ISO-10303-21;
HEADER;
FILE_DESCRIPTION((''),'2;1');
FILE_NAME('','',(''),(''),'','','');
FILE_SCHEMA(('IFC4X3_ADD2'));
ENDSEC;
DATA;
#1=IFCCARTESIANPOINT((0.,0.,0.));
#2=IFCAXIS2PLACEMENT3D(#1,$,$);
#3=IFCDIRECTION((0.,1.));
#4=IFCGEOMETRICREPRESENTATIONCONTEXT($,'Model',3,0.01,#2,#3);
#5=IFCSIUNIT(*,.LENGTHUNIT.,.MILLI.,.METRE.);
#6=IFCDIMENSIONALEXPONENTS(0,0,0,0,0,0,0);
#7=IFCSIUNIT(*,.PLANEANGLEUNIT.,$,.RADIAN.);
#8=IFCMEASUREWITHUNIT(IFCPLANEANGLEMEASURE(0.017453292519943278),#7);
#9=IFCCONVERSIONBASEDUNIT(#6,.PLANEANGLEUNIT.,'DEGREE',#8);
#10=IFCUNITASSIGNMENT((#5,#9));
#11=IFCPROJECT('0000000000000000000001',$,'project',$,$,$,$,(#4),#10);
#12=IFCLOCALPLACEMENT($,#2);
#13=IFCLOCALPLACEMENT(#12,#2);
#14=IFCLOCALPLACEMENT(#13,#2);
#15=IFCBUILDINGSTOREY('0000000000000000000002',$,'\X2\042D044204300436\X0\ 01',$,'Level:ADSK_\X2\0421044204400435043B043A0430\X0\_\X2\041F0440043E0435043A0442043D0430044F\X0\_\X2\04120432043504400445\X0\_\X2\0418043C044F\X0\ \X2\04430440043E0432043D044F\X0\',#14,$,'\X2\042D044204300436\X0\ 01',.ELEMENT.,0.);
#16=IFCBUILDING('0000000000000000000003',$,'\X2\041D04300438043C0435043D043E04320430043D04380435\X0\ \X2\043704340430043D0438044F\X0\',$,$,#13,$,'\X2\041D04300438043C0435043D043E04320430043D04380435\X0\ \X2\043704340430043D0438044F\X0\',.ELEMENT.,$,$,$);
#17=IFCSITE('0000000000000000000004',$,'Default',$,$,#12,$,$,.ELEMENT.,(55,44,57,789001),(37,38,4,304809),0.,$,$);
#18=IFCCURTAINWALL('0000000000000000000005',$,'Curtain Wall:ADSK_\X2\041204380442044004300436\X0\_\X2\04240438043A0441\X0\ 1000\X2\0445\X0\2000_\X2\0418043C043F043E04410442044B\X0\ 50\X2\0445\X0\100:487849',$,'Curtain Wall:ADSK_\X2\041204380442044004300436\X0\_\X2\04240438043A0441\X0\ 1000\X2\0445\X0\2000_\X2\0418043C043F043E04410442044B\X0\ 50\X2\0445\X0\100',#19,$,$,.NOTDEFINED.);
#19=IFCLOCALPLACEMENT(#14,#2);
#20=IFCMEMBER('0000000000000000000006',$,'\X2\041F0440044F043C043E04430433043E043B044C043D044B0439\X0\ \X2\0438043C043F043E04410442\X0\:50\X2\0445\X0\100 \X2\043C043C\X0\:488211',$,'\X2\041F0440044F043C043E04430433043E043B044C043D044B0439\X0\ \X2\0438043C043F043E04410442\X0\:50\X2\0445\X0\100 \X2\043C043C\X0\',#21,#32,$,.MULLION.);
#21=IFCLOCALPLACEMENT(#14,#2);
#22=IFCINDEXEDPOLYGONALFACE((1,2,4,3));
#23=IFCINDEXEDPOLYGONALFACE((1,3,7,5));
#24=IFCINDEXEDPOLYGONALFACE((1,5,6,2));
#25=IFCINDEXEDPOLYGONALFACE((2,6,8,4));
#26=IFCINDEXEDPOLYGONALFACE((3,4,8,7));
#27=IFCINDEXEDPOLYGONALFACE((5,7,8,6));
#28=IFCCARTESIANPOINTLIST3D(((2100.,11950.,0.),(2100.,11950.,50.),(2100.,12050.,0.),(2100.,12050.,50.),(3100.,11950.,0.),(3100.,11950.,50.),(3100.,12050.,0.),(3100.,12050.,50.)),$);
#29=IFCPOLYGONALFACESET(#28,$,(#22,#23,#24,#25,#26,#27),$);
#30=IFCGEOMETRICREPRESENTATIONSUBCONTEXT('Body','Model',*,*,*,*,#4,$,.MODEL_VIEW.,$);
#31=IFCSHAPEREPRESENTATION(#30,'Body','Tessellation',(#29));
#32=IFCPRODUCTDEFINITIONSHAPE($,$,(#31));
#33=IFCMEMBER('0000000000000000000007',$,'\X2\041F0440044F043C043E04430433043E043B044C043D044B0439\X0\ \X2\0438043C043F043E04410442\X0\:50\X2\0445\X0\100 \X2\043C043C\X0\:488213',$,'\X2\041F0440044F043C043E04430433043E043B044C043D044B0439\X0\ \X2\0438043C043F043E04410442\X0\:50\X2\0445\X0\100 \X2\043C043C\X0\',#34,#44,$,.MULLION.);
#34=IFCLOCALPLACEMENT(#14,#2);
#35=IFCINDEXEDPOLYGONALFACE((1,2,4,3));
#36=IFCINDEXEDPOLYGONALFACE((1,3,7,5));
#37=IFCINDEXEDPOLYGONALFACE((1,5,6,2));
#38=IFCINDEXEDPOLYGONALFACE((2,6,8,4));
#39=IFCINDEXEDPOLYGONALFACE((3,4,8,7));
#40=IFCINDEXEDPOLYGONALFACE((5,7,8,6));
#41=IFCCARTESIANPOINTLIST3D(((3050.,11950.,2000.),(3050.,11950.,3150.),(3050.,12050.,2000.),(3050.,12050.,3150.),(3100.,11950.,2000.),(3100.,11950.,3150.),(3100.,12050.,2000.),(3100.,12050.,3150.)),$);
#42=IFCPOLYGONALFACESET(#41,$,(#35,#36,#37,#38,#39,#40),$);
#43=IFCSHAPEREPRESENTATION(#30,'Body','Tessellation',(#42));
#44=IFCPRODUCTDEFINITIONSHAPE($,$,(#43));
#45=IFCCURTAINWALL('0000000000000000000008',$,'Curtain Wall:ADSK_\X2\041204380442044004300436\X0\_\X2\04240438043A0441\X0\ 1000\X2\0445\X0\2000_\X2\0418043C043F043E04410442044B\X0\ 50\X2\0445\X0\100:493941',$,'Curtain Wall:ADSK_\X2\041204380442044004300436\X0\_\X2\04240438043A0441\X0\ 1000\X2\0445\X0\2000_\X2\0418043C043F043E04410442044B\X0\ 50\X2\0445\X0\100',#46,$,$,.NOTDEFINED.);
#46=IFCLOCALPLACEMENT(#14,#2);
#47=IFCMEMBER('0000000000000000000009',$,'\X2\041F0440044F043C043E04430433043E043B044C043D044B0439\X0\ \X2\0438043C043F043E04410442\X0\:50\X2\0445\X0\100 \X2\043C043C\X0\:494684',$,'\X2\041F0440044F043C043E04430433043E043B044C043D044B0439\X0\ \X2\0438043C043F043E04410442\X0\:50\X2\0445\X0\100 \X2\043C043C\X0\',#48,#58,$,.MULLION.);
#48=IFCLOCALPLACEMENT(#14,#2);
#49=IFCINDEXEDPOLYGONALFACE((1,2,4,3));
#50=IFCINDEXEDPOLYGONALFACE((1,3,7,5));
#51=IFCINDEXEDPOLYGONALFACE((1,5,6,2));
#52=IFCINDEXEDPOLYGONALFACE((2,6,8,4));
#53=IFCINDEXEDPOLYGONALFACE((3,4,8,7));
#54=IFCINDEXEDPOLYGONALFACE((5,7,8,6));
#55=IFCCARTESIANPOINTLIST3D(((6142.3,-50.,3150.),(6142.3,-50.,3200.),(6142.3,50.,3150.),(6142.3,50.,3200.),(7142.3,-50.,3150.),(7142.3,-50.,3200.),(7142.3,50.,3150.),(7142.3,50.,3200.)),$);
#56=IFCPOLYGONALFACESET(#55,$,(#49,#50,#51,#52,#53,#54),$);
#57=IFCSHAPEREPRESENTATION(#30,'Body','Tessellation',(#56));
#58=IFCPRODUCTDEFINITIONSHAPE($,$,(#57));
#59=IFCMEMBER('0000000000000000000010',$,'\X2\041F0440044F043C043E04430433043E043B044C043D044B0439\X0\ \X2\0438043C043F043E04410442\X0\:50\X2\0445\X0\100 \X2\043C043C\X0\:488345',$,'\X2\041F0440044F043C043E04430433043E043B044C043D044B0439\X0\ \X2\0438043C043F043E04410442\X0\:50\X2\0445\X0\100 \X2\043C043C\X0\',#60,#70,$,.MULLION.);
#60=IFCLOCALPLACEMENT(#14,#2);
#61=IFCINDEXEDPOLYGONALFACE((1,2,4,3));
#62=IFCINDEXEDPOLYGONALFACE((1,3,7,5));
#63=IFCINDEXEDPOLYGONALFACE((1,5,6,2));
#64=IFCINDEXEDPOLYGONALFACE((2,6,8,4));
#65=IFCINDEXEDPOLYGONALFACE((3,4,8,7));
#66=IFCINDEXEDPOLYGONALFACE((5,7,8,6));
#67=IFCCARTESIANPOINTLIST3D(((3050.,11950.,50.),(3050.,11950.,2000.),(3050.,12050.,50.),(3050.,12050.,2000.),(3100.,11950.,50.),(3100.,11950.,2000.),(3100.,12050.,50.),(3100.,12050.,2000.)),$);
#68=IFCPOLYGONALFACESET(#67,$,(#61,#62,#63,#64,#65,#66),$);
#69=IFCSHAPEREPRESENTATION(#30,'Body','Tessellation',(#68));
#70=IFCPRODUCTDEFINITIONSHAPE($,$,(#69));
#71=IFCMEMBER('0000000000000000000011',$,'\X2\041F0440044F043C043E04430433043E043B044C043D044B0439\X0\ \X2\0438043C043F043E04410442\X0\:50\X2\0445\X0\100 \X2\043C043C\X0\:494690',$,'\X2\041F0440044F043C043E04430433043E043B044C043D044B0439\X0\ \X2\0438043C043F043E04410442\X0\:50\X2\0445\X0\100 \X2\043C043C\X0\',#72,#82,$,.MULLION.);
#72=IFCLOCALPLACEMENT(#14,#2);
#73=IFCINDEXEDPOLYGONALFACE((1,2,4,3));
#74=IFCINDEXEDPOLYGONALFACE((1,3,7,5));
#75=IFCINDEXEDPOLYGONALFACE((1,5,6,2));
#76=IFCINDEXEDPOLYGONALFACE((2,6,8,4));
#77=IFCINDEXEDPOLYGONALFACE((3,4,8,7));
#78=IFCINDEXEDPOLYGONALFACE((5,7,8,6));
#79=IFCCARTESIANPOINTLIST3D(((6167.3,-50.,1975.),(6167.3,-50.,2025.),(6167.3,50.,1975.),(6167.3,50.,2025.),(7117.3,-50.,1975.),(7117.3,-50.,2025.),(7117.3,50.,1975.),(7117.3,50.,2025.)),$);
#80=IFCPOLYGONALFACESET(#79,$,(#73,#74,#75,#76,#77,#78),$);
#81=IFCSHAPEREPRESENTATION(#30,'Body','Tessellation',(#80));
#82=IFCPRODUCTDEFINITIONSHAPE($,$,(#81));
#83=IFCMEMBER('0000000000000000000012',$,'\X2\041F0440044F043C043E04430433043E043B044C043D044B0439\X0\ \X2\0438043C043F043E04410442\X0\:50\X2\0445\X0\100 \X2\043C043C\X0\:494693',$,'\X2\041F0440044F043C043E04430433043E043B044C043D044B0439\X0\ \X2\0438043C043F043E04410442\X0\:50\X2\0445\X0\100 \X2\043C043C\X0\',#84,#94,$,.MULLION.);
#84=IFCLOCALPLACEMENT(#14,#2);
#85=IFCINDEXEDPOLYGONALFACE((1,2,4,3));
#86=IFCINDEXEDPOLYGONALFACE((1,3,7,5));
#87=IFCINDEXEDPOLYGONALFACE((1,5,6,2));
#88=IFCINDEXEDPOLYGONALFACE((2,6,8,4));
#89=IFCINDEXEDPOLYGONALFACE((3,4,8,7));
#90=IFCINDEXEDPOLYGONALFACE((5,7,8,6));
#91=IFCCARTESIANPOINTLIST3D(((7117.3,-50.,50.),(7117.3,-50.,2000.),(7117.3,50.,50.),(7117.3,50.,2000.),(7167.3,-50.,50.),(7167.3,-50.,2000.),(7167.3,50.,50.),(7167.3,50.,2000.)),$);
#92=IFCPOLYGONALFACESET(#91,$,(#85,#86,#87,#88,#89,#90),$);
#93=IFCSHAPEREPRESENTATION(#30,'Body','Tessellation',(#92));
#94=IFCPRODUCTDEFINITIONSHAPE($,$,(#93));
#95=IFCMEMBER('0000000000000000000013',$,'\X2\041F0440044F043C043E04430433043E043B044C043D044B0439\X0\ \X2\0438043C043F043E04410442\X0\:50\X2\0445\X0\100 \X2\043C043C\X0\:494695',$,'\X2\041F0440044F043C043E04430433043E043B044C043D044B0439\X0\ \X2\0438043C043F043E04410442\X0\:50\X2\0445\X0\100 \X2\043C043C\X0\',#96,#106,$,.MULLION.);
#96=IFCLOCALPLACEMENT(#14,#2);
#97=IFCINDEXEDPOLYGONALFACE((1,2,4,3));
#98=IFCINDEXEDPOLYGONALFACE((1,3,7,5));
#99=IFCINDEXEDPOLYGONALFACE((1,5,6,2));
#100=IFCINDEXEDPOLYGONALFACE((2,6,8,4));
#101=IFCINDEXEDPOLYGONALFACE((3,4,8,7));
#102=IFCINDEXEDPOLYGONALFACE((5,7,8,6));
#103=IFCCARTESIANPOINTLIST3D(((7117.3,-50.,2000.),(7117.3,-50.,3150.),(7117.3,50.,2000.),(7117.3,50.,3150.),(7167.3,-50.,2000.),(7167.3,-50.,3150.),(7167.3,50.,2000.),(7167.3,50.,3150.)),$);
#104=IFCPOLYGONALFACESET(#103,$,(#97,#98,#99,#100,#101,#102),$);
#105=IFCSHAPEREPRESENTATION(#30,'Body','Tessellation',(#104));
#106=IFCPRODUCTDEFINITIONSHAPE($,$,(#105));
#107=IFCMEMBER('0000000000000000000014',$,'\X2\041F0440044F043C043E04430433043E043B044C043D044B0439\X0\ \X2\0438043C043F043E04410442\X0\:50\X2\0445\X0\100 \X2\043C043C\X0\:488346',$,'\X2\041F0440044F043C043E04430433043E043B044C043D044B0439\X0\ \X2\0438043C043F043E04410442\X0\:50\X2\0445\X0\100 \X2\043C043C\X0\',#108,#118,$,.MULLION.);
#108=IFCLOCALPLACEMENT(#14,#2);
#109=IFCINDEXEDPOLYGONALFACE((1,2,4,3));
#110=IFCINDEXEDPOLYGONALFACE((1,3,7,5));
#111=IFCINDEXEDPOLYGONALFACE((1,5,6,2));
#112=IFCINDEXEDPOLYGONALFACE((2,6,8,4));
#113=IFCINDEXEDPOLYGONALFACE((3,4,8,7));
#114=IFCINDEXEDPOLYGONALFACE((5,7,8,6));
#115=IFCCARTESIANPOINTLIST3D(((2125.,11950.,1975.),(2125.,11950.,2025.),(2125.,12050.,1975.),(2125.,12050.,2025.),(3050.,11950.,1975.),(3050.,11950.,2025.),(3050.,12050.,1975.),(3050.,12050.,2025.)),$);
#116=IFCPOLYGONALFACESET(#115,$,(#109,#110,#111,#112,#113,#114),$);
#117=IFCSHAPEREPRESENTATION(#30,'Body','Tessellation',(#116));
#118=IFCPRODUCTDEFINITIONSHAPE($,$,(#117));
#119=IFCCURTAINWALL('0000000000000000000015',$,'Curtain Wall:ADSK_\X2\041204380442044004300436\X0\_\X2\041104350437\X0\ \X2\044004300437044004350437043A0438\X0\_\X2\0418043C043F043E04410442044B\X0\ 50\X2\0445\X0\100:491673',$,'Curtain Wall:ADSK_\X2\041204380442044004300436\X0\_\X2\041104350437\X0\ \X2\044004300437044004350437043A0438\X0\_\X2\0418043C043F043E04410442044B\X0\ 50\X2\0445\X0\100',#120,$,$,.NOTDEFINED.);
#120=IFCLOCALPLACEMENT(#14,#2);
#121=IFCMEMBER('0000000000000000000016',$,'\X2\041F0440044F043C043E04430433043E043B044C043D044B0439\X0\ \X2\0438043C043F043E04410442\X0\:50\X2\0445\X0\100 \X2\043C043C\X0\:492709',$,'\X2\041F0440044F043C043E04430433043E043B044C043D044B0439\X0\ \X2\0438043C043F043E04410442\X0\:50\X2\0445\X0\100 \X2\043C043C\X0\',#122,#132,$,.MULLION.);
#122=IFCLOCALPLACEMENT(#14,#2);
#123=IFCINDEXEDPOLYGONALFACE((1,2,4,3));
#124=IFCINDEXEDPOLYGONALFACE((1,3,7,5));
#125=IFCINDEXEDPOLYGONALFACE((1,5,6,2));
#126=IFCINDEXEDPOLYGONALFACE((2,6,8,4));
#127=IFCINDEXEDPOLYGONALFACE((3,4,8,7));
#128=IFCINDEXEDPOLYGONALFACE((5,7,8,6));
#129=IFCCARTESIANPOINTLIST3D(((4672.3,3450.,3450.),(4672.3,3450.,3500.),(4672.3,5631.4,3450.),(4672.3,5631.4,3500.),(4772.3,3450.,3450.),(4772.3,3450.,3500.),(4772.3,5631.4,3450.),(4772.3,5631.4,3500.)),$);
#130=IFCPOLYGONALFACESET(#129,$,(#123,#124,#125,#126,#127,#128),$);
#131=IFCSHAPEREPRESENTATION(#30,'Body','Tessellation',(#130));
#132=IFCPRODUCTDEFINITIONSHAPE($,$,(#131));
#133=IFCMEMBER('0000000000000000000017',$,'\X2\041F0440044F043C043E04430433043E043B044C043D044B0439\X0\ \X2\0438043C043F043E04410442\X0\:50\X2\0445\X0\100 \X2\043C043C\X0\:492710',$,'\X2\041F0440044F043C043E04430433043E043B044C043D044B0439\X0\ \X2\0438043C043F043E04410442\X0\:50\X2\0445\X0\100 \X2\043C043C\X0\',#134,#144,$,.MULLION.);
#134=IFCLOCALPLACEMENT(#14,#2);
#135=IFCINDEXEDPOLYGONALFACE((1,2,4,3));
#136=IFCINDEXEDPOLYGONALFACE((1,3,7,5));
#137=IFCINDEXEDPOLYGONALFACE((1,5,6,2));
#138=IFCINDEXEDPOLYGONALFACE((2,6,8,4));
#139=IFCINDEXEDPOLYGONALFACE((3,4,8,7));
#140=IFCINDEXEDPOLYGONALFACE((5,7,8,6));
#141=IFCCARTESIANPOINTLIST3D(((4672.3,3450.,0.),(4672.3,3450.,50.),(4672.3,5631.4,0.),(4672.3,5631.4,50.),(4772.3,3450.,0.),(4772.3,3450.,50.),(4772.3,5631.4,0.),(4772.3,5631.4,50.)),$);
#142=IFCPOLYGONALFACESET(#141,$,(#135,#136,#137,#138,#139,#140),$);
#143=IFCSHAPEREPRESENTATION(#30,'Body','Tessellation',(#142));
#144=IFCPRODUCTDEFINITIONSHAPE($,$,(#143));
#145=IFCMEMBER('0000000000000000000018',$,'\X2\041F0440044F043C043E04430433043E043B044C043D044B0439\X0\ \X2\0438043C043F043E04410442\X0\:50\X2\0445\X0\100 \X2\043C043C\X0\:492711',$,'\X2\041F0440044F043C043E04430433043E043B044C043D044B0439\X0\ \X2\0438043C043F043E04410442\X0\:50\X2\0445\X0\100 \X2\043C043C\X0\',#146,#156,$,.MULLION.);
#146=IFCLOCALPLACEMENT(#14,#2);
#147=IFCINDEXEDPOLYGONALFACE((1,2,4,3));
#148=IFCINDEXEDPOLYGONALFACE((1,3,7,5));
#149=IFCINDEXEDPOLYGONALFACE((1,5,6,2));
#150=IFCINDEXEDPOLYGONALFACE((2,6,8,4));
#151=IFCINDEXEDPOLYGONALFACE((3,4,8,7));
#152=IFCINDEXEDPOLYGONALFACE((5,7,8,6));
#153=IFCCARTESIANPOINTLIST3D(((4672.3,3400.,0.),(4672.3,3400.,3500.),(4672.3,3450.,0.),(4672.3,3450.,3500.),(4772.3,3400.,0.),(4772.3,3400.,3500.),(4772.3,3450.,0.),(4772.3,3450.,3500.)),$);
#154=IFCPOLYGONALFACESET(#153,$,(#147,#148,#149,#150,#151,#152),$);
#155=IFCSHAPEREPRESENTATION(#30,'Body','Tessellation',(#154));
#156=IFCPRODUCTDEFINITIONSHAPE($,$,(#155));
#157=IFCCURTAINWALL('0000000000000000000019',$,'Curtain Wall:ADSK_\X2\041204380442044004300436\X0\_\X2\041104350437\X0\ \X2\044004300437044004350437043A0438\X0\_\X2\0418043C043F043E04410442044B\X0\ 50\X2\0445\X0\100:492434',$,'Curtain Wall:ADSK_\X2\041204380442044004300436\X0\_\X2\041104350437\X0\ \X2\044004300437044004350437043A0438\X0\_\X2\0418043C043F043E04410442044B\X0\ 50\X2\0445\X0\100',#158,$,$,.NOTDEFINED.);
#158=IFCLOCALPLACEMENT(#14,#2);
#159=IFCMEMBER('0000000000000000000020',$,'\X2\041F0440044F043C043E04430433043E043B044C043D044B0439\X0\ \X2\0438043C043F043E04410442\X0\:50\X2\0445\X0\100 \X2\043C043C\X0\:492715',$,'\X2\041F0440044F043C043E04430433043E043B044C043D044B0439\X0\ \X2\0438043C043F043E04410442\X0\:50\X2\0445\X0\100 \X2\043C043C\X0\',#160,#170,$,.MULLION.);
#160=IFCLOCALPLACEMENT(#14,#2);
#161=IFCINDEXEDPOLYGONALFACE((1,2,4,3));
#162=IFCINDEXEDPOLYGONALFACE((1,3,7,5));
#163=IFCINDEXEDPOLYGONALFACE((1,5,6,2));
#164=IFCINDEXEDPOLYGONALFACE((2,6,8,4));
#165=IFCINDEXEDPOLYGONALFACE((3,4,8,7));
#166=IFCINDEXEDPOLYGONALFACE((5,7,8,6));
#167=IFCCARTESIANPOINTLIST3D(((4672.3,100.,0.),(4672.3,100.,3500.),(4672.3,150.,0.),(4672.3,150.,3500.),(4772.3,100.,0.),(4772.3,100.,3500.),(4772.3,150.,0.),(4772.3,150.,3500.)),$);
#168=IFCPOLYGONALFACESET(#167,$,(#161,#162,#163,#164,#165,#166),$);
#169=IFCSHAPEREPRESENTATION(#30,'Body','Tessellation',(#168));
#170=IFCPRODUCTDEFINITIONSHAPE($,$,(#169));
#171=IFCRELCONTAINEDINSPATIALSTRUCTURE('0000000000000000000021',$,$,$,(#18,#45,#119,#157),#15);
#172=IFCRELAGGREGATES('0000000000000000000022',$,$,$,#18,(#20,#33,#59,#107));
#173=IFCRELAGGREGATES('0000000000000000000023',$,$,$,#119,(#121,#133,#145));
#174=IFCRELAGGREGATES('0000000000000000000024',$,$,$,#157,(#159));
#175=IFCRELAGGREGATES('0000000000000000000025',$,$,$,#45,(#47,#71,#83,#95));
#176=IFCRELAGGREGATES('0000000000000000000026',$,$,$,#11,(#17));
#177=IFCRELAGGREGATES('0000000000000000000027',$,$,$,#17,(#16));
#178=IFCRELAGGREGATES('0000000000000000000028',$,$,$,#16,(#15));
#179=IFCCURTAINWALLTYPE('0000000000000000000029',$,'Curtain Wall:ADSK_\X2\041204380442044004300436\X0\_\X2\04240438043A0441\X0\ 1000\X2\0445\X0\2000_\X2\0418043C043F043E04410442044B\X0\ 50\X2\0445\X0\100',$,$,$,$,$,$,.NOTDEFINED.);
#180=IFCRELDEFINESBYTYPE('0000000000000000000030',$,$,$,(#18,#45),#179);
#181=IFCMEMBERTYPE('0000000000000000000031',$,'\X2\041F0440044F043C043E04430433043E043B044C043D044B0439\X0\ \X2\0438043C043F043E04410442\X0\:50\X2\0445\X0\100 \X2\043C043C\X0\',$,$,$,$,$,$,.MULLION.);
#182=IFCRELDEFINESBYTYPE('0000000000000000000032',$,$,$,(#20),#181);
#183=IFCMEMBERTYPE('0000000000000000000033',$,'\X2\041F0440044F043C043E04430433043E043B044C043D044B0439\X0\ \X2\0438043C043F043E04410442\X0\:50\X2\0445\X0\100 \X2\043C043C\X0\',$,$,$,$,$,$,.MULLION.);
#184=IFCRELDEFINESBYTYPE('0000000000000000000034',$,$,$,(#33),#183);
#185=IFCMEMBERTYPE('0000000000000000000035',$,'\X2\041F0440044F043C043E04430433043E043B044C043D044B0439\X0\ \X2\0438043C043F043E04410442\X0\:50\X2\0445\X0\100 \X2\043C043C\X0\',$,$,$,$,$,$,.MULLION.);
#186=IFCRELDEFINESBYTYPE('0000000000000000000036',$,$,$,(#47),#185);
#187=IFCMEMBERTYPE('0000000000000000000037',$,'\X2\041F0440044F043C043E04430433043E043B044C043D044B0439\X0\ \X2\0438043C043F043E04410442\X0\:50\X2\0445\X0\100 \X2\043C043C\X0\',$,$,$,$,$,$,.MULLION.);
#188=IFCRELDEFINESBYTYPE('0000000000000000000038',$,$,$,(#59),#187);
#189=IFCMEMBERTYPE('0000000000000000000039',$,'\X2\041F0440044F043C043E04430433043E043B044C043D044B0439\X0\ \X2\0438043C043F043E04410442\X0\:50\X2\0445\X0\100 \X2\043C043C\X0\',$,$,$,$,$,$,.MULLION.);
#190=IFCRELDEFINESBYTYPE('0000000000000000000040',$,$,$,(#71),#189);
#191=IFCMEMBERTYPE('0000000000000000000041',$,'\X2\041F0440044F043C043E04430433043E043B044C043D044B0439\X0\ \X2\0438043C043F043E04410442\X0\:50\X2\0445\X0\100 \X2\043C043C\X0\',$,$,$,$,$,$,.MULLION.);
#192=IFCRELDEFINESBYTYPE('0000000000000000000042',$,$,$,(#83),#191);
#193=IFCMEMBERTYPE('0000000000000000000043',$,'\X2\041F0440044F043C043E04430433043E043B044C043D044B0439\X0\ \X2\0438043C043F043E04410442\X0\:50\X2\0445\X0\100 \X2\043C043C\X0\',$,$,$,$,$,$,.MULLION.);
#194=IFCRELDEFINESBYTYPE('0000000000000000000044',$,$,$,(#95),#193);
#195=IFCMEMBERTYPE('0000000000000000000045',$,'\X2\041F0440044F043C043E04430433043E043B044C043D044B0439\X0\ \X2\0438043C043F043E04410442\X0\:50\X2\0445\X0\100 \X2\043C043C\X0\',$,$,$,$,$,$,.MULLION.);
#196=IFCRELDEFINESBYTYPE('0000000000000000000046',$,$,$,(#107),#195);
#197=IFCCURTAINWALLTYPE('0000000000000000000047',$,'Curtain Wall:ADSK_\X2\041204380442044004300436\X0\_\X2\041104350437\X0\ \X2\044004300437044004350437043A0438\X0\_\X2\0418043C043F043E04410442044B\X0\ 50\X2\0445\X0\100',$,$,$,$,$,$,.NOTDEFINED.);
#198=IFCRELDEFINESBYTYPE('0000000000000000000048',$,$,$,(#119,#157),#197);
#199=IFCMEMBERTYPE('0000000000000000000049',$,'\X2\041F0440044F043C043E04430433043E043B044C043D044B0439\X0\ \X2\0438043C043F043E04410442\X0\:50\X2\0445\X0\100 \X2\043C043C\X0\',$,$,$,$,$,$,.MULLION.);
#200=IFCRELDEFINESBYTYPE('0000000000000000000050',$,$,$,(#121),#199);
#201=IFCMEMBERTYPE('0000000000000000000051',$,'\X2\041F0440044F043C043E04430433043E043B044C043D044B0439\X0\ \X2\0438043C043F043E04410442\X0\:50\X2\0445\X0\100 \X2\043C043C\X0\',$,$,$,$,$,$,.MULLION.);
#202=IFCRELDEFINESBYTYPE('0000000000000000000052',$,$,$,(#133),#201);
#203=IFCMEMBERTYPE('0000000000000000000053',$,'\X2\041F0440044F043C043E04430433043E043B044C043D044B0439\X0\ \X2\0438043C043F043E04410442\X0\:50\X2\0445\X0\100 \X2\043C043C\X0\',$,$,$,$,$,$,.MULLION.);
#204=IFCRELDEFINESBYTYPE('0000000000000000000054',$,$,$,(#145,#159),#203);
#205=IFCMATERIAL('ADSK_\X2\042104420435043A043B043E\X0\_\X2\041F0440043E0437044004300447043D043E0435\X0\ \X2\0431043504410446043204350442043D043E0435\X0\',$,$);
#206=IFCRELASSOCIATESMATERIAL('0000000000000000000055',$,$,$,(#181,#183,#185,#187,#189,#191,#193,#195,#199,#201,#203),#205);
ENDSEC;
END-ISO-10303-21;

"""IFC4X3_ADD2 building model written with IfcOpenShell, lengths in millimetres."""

from ifc_helpers import new_model, entity, si_unit, converted_unit, direction, frame, frame_2d, origin, origin_2d_with_axis, place, context, subcontext, project, spatial, rectangle, extrude, source, transform, mapped, material, material_profile, profile_set, type_object, type_shapes, element, aggregate, save


model = new_model("IFC4X3_ADD2")

# Units and contexts
model_context = context("Model", 3, precision=0.01, world=origin(), true_north=direction((0.0, 1.0)))
body_context = subcontext(model_context, "Body", "Model", "MODEL_VIEW")
ifc_project = project(units=[si_unit("LENGTHUNIT", "METRE", prefix="MILLI"), converted_unit("PLANEANGLEUNIT", "DEGREE", entity("IfcPlaneAngleMeasure", 0.017453292519943278), si_unit("PLANEANGLEUNIT", "RADIAN"), dimensions=[0, 0, 0, 0, 0, 0, 0])], contexts=[model_context])

# Site, building, storey
site_placement = place(None, origin())
site = spatial("IfcSite", under=ifc_project, at=site_placement, Name="Default", CompositionType="ELEMENT", RefLatitude=(55, 44, 57, 789001), RefLongitude=(37, 38, 4, 304809), RefElevation=0.0)
building_placement = place(site_placement, origin())
building = spatial("IfcBuilding", under=site, at=building_placement, Name="Наименование здания", LongName="Наименование здания", CompositionType="ELEMENT")
storey_placement = place(building_placement, origin())
storey = spatial("IfcBuildingStorey", under=building, at=storey_placement, Name="Этаж 01", ObjectType="Level:ADSK_Стрелка_Проектная_Вверх_Имя уровня", LongName="Этаж 01", CompositionType="ELEMENT", Elevation=0.0)

# Curtain wall, members
curtain_wall_type_1 = type_object("IfcCurtainWallType", Name="Curtain Wall:ADSK_Витраж_Фикс 1000х2000_Импосты 50х100", PredefinedType="NOTDEFINED")
curtain_wall_1_placement = place(storey_placement, origin())
curtain_wall_1 = element("IfcCurtainWall", 1, at=curtain_wall_1_placement, inside=storey, type_object=curtain_wall_type_1, Name="Curtain Wall:ADSK_Витраж_Фикс 1000х2000_Импосты 50х100:487849", ObjectType="Curtain Wall:ADSK_Витраж_Фикс 1000х2000_Импосты 50х100", PredefinedType="NOTDEFINED")
ifc_material_1 = material(Name="ADSK_Стекло_Прозрачное бесцветное")
ifc_material_profile = material_profile(ifc_material_1, rectangle(XDim=50.0, YDim=100.0, at=frame_2d((0.0, 0.0), x_axis=(1.0, 0.0))), Name="50х100 мм")
ifc_profile_set = profile_set([ifc_material_profile], Name="50х100 мм")
member_type_1 = type_object("IfcMemberType", Name="Прямоугольный импост:50х100 мм", PredefinedType="MULLION", material=ifc_profile_set)
shared_shape_1 = source(origin(), body_context, "Body", "SweptSolid", [
    extrude(rectangle(XDim=50.0, YDim=100.0, at=frame_2d((0.0, 0.0), x_axis=(1.0, 0.0))), frame((-25.0, 0.0, -1000.0), z_axis=(0.0, 0.0, 1.0), x_axis=(-1.0, 0.0, 0.0)), (0.0, 0.0, 1.0), 1000.0),
])
type_shapes(member_type_1, [shared_shape_1])
member_1_placement = place(curtain_wall_1_placement, frame((3100.0, 12000.0, 0.0), z_axis=(1.0, 0.0, 0.0), x_axis=(0.0, 0.0, -1.0)))
member_1 = element("IfcMember", 2, at=member_1_placement, type_object=member_type_1, Name="Прямоугольный импост:50х100 мм:488211", ObjectType="Прямоугольный импост:50х100 мм", PredefinedType="MULLION", context=body_context, shape_type="MappedRepresentation", body=[
    mapped(shared_shape_1, transform((0.0, 0.0, 0.0), scale=1.0)),
])
member_type_2 = type_object("IfcMemberType", Name="Прямоугольный импост:50х100 мм", PredefinedType="MULLION", material=ifc_profile_set)
shared_shape_2 = source(origin(), body_context, "Body", "SweptSolid", [
    extrude(rectangle(XDim=50.0, YDim=100.0, at=frame_2d((0.0, 0.0), x_axis=(1.0, 0.0))), frame((-25.0, 0.0, -1150.0), z_axis=(0.0, 0.0, 1.0), x_axis=(-1.0, 0.0, 0.0)), (0.0, 0.0, 1.0), 1150.0),
])
type_shapes(member_type_2, [shared_shape_2])
member_2_placement = place(curtain_wall_1_placement, frame((3100.0, 12000.0, 3150.0)))
member_2 = element("IfcMember", 3, at=member_2_placement, type_object=member_type_2, Name="Прямоугольный импост:50х100 мм:488213", ObjectType="Прямоугольный импост:50х100 мм", PredefinedType="MULLION", context=body_context, shape_type="MappedRepresentation", body=[
    mapped(shared_shape_2, transform((0.0, 0.0, 0.0), scale=1.0)),
])

# Curtain wall, member
curtain_wall_2_placement = place(storey_placement, origin())
curtain_wall_2 = element("IfcCurtainWall", 4, at=curtain_wall_2_placement, inside=storey, type_object=curtain_wall_type_1, Name="Curtain Wall:ADSK_Витраж_Фикс 1000х2000_Импосты 50х100:493941", ObjectType="Curtain Wall:ADSK_Витраж_Фикс 1000х2000_Импосты 50х100", PredefinedType="NOTDEFINED")
member_type_3 = type_object("IfcMemberType", Name="Прямоугольный импост:50х100 мм", PredefinedType="MULLION", material=ifc_profile_set)
shared_shape_3 = source(origin(), body_context, "Body", "SweptSolid", [
    extrude(rectangle(XDim=50.0, YDim=100.0, at=frame_2d((0.0, 0.0), x_axis=(1.0, 0.0))), frame((-25.0, 0.0, -1000.0), z_axis=(0.0, 0.0, 1.0), x_axis=(-1.0, 0.0, 0.0)), (0.0, 0.0, 1.0), 1000.0),
])
type_shapes(member_type_3, [shared_shape_3])
member_3_placement = place(curtain_wall_2_placement, frame((7142.3, 0.0, 3200.0), z_axis=(1.0, 0.0, 0.0), x_axis=(0.0, 0.0, 1.0)))
member_3 = element("IfcMember", 5, at=member_3_placement, type_object=member_type_3, Name="Прямоугольный импост:50х100 мм:494684", ObjectType="Прямоугольный импост:50х100 мм", PredefinedType="MULLION", context=body_context, shape_type="MappedRepresentation", body=[
    mapped(shared_shape_3, transform((0.0, 0.0, 0.0), scale=1.0)),
])

# Members
member_type_4 = type_object("IfcMemberType", Name="Прямоугольный импост:50х100 мм", PredefinedType="MULLION", material=ifc_profile_set)
shared_shape_4 = source(origin(), body_context, "Body", "SweptSolid", [
    extrude(rectangle(XDim=50.0, YDim=100.0, at=frame_2d((0.0, 0.0), x_axis=(1.0, 0.0))), frame((-25.0, 0.0, -1950.0), z_axis=(0.0, 0.0, 1.0), x_axis=(-1.0, 0.0, 0.0)), (0.0, 0.0, 1.0), 1950.0),
])
type_shapes(member_type_4, [shared_shape_4])
member_4_placement = place(curtain_wall_1_placement, frame((3100.0, 12000.0, 2000.0)))
member_4 = element("IfcMember", 6, at=member_4_placement, type_object=member_type_4, Name="Прямоугольный импост:50х100 мм:488345", ObjectType="Прямоугольный импост:50х100 мм", PredefinedType="MULLION", context=body_context, shape_type="MappedRepresentation", body=[
    mapped(shared_shape_4, transform((0.0, 0.0, 0.0), scale=1.0)),
])
member_type_5 = type_object("IfcMemberType", Name="Прямоугольный импост:50х100 мм", PredefinedType="MULLION", material=ifc_profile_set)
shared_shape_5 = source(origin(), body_context, "Body", "SweptSolid", [
    extrude(rectangle(XDim=50.0, YDim=100.0, at=frame_2d((0.0, 0.0), x_axis=(1.0, 0.0))), frame((0.0, 0.0, -950.0), z_axis=(0.0, 0.0, 1.0), x_axis=(-1.0, 0.0, 0.0)), (0.0, 0.0, 1.0), 950.0),
])
type_shapes(member_type_5, [shared_shape_5])
member_5_placement = place(curtain_wall_2_placement, frame((7117.3, 0.0, 2000.0), z_axis=(1.0, 0.0, 0.0), x_axis=(0.0, 0.0, 1.0)))
member_5 = element("IfcMember", 7, at=member_5_placement, type_object=member_type_5, Name="Прямоугольный импост:50х100 мм:494690", ObjectType="Прямоугольный импост:50х100 мм", PredefinedType="MULLION", context=body_context, shape_type="MappedRepresentation", body=[
    mapped(shared_shape_5, transform((0.0, 0.0, 0.0), scale=1.0)),
])
member_type_6 = type_object("IfcMemberType", Name="Прямоугольный импост:50х100 мм", PredefinedType="MULLION", material=ifc_profile_set)
shared_shape_6 = source(origin(), body_context, "Body", "SweptSolid", [
    extrude(rectangle(XDim=50.0, YDim=100.0, at=frame_2d((0.0, 0.0), x_axis=(1.0, 0.0))), frame((0.0, 0.0, -1950.0), z_axis=(0.0, 0.0, 1.0), x_axis=(-1.0, 0.0, 0.0)), (0.0, 0.0, 1.0), 1950.0),
])
type_shapes(member_type_6, [shared_shape_6])
member_6_placement = place(curtain_wall_2_placement, frame((7142.3, 0.0, 50.0), z_axis=(0.0, 0.0, -1.0), x_axis=(1.0, 0.0, 0.0)))
member_6 = element("IfcMember", 8, at=member_6_placement, type_object=member_type_6, Name="Прямоугольный импост:50х100 мм:494693", ObjectType="Прямоугольный импост:50х100 мм", PredefinedType="MULLION", context=body_context, shape_type="MappedRepresentation", body=[
    mapped(shared_shape_6, transform((0.0, 0.0, 0.0), scale=1.0)),
])
member_type_7 = type_object("IfcMemberType", Name="Прямоугольный импост:50х100 мм", PredefinedType="MULLION", material=ifc_profile_set)
shared_shape_7 = source(origin(), body_context, "Body", "SweptSolid", [
    extrude(rectangle(XDim=50.0, YDim=100.0, at=frame_2d((0.0, 0.0), x_axis=(1.0, 0.0))), frame((0.0, 0.0, -1150.0), z_axis=(0.0, 0.0, 1.0), x_axis=(-1.0, 0.0, 0.0)), (0.0, 0.0, 1.0), 1150.0),
])
type_shapes(member_type_7, [shared_shape_7])
member_7_placement = place(curtain_wall_2_placement, frame((7142.3, 0.0, 2000.0), z_axis=(0.0, 0.0, -1.0), x_axis=(1.0, 0.0, 0.0)))
member_7 = element("IfcMember", 9, at=member_7_placement, type_object=member_type_7, Name="Прямоугольный импост:50х100 мм:494695", ObjectType="Прямоугольный импост:50х100 мм", PredefinedType="MULLION", context=body_context, shape_type="MappedRepresentation", body=[
    mapped(shared_shape_7, transform((0.0, 0.0, 0.0), scale=1.0)),
])
member_type_8 = type_object("IfcMemberType", Name="Прямоугольный импост:50х100 мм", PredefinedType="MULLION", material=ifc_profile_set)
shared_shape_8 = source(origin(), body_context, "Body", "SweptSolid", [
    extrude(rectangle(XDim=50.0, YDim=100.0, at=frame_2d((0.0, 0.0), x_axis=(1.0, 0.0))), frame((0.0, 0.0, -925.0), z_axis=(0.0, 0.0, 1.0), x_axis=(-1.0, 0.0, 0.0)), (0.0, 0.0, 1.0), 925.0),
])
type_shapes(member_type_8, [shared_shape_8])
member_8_placement = place(curtain_wall_1_placement, frame((2125.0, 12000.0, 2000.0), z_axis=(-1.0, 0.0, 0.0), x_axis=(0.0, 0.0, 1.0)))
member_8 = element("IfcMember", 10, at=member_8_placement, type_object=member_type_8, Name="Прямоугольный импост:50х100 мм:488346", ObjectType="Прямоугольный импост:50х100 мм", PredefinedType="MULLION", context=body_context, shape_type="MappedRepresentation", body=[
    mapped(shared_shape_8, transform((0.0, 0.0, 0.0), scale=1.0)),
])

# Curtain wall, members
curtain_wall_type_2 = type_object("IfcCurtainWallType", Name="Curtain Wall:ADSK_Витраж_Без разрезки_Импосты 50х100", PredefinedType="NOTDEFINED")
curtain_wall_3_placement = place(storey_placement, origin())
curtain_wall_3 = element("IfcCurtainWall", 11, at=curtain_wall_3_placement, inside=storey, type_object=curtain_wall_type_2, Name="Curtain Wall:ADSK_Витраж_Без разрезки_Импосты 50х100:491673", ObjectType="Curtain Wall:ADSK_Витраж_Без разрезки_Импосты 50х100", PredefinedType="NOTDEFINED")
member_type_9 = type_object("IfcMemberType", Name="Прямоугольный импост:50х100 мм", PredefinedType="MULLION", material=ifc_profile_set)
shared_shape_9 = source(origin(), body_context, "Body", "SweptSolid", [
    extrude(rectangle(XDim=50.0, YDim=100.0, at=frame_2d((0.0, 0.0), x_axis=(1.0, 0.0))), frame((-25.0, 0.0, -2181.4), z_axis=(0.0, 0.0, 1.0), x_axis=(-1.0, 0.0, 0.0)), (0.0, 0.0, 1.0), 2181.4),
])
type_shapes(member_type_9, [shared_shape_9])
member_9_placement = place(curtain_wall_3_placement, frame((4722.3, 3450.0, 3500.0), z_axis=(0.0, -1.0, 0.0), x_axis=(0.0, 0.0, 1.0)))
member_9 = element("IfcMember", 12, at=member_9_placement, type_object=member_type_9, Name="Прямоугольный импост:50х100 мм:492709", ObjectType="Прямоугольный импост:50х100 мм", PredefinedType="MULLION", context=body_context, shape_type="MappedRepresentation", body=[
    mapped(shared_shape_9, transform((0.0, 0.0, 0.0), scale=1.0)),
])
member_type_10 = type_object("IfcMemberType", Name="Прямоугольный импост:50х100 мм", PredefinedType="MULLION", material=ifc_profile_set)
shared_shape_10 = source(origin(), body_context, "Body", "SweptSolid", [
    extrude(rectangle(XDim=50.0, YDim=100.0, at=frame_2d((0.0, 0.0), x_axis=(1.0, 0.0))), frame((-25.0, 0.0, -2181.4), z_axis=(0.0, 0.0, 1.0), x_axis=(-1.0, 0.0, 0.0)), (0.0, 0.0, 1.0), 2181.4),
])
type_shapes(member_type_10, [shared_shape_10])
member_10_placement = place(curtain_wall_3_placement, frame((4722.3, 5631.4, 0.0), z_axis=(0.0, 1.0, 0.0), x_axis=(0.0, 0.0, -1.0)))
member_10 = element("IfcMember", 13, at=member_10_placement, type_object=member_type_10, Name="Прямоугольный импост:50х100 мм:492710", ObjectType="Прямоугольный импост:50х100 мм", PredefinedType="MULLION", context=body_context, shape_type="MappedRepresentation", body=[
    mapped(shared_shape_10, transform((0.0, 0.0, 0.0), scale=1.0)),
])
member_type_11 = type_object("IfcMemberType", Name="Прямоугольный импост:50х100 мм", PredefinedType="MULLION", material=ifc_profile_set)
shared_shape_11 = source(origin(), body_context, "Body", "SweptSolid", [
    extrude(rectangle(XDim=50.0, YDim=100.0, at=origin_2d_with_axis()), frame((-25.0, 0.0, -3500.0), z_axis=(0.0, 0.0, 1.0), x_axis=(-1.0, 0.0, 0.0)), (0.0, 0.0, 1.0), 3500.0),
])
type_shapes(member_type_11, [shared_shape_11])
member_11_placement = place(curtain_wall_3_placement, frame((4722.3, 3400.0, 0.0), z_axis=(0.0, 0.0, -1.0), x_axis=(0.0, -1.0, 0.0)))
member_11 = element("IfcMember", 14, at=member_11_placement, type_object=member_type_11, Name="Прямоугольный импост:50х100 мм:492711", ObjectType="Прямоугольный импост:50х100 мм", PredefinedType="MULLION", context=body_context, shape_type="MappedRepresentation", body=[
    mapped(shared_shape_11, transform((0.0, 0.0, 0.0), scale=1.0)),
])

# Curtain wall, member
curtain_wall_4_placement = place(storey_placement, origin())
curtain_wall_4 = element("IfcCurtainWall", 15, at=curtain_wall_4_placement, inside=storey, type_object=curtain_wall_type_2, Name="Curtain Wall:ADSK_Витраж_Без разрезки_Импосты 50х100:492434", ObjectType="Curtain Wall:ADSK_Витраж_Без разрезки_Импосты 50х100", PredefinedType="NOTDEFINED")
member_12_placement = place(curtain_wall_4_placement, frame((4722.3, 100.0, 0.0), z_axis=(0.0, 0.0, -1.0), x_axis=(0.0, -1.0, 0.0)))
member_12 = element("IfcMember", 16, at=member_12_placement, type_object=member_type_11, Name="Прямоугольный импост:50х100 мм:492715", ObjectType="Прямоугольный импост:50х100 мм", PredefinedType="MULLION", context=body_context, shape_type="MappedRepresentation", body=[
    mapped(shared_shape_11, transform((0.0, 0.0, 0.0), scale=1.0)),
])

aggregate(curtain_wall_1, [member_1, member_2, member_4, member_8])
aggregate(curtain_wall_3, [member_9, member_10, member_11])
aggregate(curtain_wall_4, [member_12])
aggregate(curtain_wall_2, [member_3, member_5, member_6, member_7])

save(model, "model.ifc")
